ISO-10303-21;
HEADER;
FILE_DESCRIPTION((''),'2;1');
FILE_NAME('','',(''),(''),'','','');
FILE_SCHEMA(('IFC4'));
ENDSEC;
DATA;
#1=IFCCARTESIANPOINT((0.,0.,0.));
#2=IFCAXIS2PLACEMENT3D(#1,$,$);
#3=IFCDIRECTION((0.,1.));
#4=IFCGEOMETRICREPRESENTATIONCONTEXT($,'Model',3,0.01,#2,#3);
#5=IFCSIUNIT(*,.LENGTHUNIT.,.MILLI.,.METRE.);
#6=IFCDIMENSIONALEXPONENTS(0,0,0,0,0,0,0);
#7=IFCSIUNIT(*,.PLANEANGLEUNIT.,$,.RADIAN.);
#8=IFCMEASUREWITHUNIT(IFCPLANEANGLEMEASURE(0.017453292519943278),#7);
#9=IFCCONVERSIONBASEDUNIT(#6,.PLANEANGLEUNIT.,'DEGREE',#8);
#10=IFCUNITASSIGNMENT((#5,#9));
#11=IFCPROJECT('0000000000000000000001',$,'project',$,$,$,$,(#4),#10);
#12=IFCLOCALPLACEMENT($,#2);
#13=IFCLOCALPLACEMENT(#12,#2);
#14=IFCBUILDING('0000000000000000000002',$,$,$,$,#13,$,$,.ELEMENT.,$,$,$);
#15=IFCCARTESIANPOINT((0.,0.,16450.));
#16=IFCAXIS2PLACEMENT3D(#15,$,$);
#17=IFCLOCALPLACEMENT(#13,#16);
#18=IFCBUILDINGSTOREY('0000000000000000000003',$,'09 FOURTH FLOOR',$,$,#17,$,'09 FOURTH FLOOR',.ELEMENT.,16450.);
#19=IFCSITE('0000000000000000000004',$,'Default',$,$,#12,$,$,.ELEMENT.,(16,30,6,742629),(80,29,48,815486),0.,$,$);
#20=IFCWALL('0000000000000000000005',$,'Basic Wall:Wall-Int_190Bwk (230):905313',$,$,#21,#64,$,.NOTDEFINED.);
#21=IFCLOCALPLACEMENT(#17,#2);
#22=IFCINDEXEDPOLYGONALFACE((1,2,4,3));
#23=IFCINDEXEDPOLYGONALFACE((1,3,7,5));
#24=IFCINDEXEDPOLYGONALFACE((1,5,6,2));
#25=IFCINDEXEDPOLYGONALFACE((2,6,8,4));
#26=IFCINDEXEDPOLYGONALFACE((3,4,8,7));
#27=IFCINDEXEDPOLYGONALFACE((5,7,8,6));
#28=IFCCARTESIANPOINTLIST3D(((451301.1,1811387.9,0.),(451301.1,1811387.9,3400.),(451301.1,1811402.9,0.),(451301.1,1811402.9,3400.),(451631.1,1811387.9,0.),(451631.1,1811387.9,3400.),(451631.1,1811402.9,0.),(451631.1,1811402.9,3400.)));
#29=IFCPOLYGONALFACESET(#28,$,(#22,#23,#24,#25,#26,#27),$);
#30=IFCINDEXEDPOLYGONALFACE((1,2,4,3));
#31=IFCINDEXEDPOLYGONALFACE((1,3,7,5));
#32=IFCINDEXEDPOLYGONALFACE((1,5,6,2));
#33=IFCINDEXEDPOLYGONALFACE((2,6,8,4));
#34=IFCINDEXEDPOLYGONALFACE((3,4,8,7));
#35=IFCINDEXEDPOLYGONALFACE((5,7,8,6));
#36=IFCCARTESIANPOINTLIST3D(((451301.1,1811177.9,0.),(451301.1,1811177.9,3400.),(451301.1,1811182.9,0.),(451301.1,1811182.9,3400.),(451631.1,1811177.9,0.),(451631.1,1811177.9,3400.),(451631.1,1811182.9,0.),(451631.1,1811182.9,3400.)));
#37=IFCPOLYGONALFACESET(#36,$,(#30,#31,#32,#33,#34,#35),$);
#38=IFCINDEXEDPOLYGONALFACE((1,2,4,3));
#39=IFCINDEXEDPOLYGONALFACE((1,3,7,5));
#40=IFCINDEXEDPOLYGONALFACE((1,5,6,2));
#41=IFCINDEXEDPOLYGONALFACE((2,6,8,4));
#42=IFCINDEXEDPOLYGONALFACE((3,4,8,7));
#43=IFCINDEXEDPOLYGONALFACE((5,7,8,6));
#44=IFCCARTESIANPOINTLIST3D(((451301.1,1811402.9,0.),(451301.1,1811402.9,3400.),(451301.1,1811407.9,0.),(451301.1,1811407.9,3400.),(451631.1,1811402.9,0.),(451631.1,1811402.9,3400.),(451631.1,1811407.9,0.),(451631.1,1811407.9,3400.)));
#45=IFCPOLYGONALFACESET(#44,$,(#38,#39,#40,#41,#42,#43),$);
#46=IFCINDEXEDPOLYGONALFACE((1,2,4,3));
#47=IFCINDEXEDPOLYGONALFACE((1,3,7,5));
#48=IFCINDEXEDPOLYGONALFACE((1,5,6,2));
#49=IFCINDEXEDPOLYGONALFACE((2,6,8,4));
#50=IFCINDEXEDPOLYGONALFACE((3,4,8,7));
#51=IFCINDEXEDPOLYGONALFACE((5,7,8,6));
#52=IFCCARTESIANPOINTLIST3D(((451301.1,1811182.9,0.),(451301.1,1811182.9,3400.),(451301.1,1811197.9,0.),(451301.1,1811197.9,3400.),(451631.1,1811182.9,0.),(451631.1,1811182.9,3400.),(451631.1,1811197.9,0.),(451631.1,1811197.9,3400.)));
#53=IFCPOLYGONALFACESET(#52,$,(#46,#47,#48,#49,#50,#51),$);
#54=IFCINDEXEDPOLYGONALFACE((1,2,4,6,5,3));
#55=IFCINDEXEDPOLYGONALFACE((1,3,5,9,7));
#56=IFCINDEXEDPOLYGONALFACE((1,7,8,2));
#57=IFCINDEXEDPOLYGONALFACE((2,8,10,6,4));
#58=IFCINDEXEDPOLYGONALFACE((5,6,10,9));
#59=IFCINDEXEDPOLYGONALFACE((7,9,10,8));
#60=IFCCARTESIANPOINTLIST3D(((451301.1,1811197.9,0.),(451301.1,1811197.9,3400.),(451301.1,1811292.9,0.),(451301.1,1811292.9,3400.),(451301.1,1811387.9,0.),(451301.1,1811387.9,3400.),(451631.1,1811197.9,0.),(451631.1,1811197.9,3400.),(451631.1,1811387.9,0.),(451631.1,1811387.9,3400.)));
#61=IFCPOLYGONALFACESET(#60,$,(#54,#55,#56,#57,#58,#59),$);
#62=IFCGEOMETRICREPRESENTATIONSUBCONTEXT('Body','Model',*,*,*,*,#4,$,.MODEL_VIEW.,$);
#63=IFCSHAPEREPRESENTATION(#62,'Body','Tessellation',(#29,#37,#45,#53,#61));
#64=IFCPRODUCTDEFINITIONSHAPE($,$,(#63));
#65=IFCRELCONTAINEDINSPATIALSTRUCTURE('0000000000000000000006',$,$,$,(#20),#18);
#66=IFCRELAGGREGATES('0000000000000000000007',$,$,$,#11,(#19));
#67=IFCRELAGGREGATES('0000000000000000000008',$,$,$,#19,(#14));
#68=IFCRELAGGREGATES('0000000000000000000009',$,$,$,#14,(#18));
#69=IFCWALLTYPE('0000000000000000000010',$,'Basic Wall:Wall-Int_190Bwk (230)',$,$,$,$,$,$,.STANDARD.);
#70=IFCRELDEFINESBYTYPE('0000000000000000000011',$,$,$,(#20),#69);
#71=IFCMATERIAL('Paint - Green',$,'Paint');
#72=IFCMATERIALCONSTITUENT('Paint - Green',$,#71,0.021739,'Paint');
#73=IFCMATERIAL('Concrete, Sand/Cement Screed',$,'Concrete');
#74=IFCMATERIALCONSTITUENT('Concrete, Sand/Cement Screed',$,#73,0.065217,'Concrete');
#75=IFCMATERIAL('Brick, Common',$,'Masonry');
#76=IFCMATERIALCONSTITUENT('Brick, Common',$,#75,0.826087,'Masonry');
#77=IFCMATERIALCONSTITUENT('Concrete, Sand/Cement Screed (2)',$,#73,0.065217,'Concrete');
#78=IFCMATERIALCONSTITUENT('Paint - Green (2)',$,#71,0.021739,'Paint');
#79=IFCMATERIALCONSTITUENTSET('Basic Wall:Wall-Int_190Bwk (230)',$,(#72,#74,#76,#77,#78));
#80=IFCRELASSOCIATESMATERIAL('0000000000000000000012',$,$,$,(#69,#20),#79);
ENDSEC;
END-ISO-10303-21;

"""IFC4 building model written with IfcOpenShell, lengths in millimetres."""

from ifc_helpers import new_model, entity, si_unit, converted_unit, direction, frame, origin, place, context, subcontext, project, spatial, indexed_curve, outline, extrude, material, constituent, constituent_set, type_object, element, save


model = new_model("IFC4")

# Units and contexts
model_context = context("Model", 3, precision=0.01, world=origin(), true_north=direction((0.0, 1.0)))
body_context = subcontext(model_context, "Body", "Model", "MODEL_VIEW")
ifc_project = project(units=[si_unit("LENGTHUNIT", "METRE", prefix="MILLI"), converted_unit("PLANEANGLEUNIT", "DEGREE", entity("IfcPlaneAngleMeasure", 0.017453292519943278), si_unit("PLANEANGLEUNIT", "RADIAN"), dimensions=[0, 0, 0, 0, 0, 0, 0])], contexts=[model_context])

# Site, building, storey
site_placement = place(None, origin())
site = spatial("IfcSite", under=ifc_project, at=site_placement, Name="Default", CompositionType="ELEMENT", RefLatitude=(16, 30, 6, 742629), RefLongitude=(80, 29, 48, 815486), RefElevation=0.0)
building_placement = place(site_placement, origin())
building = spatial("IfcBuilding", under=site, at=building_placement, CompositionType="ELEMENT")
storey_placement = place(building_placement, frame((0.0, 0.0, 16450.0)))
storey = spatial("IfcBuildingStorey", under=building, at=storey_placement, Name="09 FOURTH FLOOR", LongName="09 FOURTH FLOOR", CompositionType="ELEMENT", Elevation=16450.0)

# Shared definitions
ifc_material_1 = material(Name="Concrete, Sand/Cement Screed", Category="Concrete")
ifc_material_2 = material(Name="Brick, Common", Category="Masonry")

# Shared definitions
ifc_material_3 = material(Name="Paint - Green", Category="Paint")

# Wall
ifc_constituent_1 = constituent(ifc_material_3, Name="Paint - Green", Category="Paint", fraction=0.021739)
ifc_constituent_2 = constituent(ifc_material_1, Name="Concrete, Sand/Cement Screed", Category="Concrete", fraction=0.065217)
ifc_constituent_3 = constituent(ifc_material_2, Name="Brick, Common", Category="Masonry", fraction=0.826087)
ifc_constituent_4 = constituent(ifc_material_1, Name="Concrete, Sand/Cement Screed (2)", Category="Concrete", fraction=0.065217)
ifc_constituent_5 = constituent(ifc_material_3, Name="Paint - Green (2)", Category="Paint", fraction=0.021739)
ifc_constituent_set_1 = constituent_set(constituents=[ifc_constituent_1, ifc_constituent_2, ifc_constituent_3, ifc_constituent_4, ifc_constituent_5], Name="Basic Wall:Wall-Int_190Bwk (230)")
wall_type_1 = type_object("IfcWallType", Name="Basic Wall:Wall-Int_190Bwk (230)", PredefinedType="STANDARD", material=ifc_constituent_set_1)
wall_1_placement = place(storey_placement, frame((451631.1, 1811292.9, 0.0), z_axis=(0.0, 0.0, 1.0), x_axis=(-1.0, 0.0, 0.0)))
element("IfcWall", 1, at=wall_1_placement, inside=storey, type_object=wall_type_1, material=ifc_constituent_set_1, Name="Basic Wall:Wall-Int_190Bwk (230):905313", PredefinedType="NOTDEFINED", context=body_context, shape_type="SweptSolid", body=[
    extrude(outline(indexed_curve([(-165.0, -7.5), (165.0, -7.5), (165.0, 7.5), (-165.0, 7.5), (-165.0, -7.5)], self_intersect=False)), frame((165.0, -102.5, 0.0)), (0.0, 0.0, 1.0), 3400.0),
    extrude(outline(indexed_curve([(-2.5, -165.0), (2.5, -165.0), (2.5, 165.0), (-2.5, 165.0), (-2.5, -165.0)], self_intersect=False)), frame((165.0, 112.5, 0.0), z_axis=(0.0, 0.0, 1.0), x_axis=(0.0, -1.0, 0.0)), (0.0, 0.0, 1.0), 3400.0),
    extrude(outline(indexed_curve([(-2.5, -165.0), (2.5, -165.0), (2.5, 165.0), (-2.5, 165.0), (-2.5, -165.0)], self_intersect=False)), frame((165.0, -112.5, 0.0), z_axis=(0.0, 0.0, 1.0), x_axis=(0.0, 1.0, 0.0)), (0.0, 0.0, 1.0), 3400.0),
    extrude(outline(indexed_curve([(-165.0, -7.5), (165.0, -7.5), (165.0, 7.5), (-165.0, 7.5), (-165.0, -7.5)], self_intersect=False)), frame((165.0, 102.5, 0.0)), (0.0, 0.0, 1.0), 3400.0),
    extrude(outline(indexed_curve([(-198.0, -95.0), (132.0, -95.0), (132.0, 0.0), (132.0, 95.0), (-198.0, 95.0), (-198.0, -95.0)], self_intersect=False)), frame((198.0, 0.0, 0.0)), (0.0, 0.0, 1.0), 3400.0),
])

save(model, "model.ifc")
